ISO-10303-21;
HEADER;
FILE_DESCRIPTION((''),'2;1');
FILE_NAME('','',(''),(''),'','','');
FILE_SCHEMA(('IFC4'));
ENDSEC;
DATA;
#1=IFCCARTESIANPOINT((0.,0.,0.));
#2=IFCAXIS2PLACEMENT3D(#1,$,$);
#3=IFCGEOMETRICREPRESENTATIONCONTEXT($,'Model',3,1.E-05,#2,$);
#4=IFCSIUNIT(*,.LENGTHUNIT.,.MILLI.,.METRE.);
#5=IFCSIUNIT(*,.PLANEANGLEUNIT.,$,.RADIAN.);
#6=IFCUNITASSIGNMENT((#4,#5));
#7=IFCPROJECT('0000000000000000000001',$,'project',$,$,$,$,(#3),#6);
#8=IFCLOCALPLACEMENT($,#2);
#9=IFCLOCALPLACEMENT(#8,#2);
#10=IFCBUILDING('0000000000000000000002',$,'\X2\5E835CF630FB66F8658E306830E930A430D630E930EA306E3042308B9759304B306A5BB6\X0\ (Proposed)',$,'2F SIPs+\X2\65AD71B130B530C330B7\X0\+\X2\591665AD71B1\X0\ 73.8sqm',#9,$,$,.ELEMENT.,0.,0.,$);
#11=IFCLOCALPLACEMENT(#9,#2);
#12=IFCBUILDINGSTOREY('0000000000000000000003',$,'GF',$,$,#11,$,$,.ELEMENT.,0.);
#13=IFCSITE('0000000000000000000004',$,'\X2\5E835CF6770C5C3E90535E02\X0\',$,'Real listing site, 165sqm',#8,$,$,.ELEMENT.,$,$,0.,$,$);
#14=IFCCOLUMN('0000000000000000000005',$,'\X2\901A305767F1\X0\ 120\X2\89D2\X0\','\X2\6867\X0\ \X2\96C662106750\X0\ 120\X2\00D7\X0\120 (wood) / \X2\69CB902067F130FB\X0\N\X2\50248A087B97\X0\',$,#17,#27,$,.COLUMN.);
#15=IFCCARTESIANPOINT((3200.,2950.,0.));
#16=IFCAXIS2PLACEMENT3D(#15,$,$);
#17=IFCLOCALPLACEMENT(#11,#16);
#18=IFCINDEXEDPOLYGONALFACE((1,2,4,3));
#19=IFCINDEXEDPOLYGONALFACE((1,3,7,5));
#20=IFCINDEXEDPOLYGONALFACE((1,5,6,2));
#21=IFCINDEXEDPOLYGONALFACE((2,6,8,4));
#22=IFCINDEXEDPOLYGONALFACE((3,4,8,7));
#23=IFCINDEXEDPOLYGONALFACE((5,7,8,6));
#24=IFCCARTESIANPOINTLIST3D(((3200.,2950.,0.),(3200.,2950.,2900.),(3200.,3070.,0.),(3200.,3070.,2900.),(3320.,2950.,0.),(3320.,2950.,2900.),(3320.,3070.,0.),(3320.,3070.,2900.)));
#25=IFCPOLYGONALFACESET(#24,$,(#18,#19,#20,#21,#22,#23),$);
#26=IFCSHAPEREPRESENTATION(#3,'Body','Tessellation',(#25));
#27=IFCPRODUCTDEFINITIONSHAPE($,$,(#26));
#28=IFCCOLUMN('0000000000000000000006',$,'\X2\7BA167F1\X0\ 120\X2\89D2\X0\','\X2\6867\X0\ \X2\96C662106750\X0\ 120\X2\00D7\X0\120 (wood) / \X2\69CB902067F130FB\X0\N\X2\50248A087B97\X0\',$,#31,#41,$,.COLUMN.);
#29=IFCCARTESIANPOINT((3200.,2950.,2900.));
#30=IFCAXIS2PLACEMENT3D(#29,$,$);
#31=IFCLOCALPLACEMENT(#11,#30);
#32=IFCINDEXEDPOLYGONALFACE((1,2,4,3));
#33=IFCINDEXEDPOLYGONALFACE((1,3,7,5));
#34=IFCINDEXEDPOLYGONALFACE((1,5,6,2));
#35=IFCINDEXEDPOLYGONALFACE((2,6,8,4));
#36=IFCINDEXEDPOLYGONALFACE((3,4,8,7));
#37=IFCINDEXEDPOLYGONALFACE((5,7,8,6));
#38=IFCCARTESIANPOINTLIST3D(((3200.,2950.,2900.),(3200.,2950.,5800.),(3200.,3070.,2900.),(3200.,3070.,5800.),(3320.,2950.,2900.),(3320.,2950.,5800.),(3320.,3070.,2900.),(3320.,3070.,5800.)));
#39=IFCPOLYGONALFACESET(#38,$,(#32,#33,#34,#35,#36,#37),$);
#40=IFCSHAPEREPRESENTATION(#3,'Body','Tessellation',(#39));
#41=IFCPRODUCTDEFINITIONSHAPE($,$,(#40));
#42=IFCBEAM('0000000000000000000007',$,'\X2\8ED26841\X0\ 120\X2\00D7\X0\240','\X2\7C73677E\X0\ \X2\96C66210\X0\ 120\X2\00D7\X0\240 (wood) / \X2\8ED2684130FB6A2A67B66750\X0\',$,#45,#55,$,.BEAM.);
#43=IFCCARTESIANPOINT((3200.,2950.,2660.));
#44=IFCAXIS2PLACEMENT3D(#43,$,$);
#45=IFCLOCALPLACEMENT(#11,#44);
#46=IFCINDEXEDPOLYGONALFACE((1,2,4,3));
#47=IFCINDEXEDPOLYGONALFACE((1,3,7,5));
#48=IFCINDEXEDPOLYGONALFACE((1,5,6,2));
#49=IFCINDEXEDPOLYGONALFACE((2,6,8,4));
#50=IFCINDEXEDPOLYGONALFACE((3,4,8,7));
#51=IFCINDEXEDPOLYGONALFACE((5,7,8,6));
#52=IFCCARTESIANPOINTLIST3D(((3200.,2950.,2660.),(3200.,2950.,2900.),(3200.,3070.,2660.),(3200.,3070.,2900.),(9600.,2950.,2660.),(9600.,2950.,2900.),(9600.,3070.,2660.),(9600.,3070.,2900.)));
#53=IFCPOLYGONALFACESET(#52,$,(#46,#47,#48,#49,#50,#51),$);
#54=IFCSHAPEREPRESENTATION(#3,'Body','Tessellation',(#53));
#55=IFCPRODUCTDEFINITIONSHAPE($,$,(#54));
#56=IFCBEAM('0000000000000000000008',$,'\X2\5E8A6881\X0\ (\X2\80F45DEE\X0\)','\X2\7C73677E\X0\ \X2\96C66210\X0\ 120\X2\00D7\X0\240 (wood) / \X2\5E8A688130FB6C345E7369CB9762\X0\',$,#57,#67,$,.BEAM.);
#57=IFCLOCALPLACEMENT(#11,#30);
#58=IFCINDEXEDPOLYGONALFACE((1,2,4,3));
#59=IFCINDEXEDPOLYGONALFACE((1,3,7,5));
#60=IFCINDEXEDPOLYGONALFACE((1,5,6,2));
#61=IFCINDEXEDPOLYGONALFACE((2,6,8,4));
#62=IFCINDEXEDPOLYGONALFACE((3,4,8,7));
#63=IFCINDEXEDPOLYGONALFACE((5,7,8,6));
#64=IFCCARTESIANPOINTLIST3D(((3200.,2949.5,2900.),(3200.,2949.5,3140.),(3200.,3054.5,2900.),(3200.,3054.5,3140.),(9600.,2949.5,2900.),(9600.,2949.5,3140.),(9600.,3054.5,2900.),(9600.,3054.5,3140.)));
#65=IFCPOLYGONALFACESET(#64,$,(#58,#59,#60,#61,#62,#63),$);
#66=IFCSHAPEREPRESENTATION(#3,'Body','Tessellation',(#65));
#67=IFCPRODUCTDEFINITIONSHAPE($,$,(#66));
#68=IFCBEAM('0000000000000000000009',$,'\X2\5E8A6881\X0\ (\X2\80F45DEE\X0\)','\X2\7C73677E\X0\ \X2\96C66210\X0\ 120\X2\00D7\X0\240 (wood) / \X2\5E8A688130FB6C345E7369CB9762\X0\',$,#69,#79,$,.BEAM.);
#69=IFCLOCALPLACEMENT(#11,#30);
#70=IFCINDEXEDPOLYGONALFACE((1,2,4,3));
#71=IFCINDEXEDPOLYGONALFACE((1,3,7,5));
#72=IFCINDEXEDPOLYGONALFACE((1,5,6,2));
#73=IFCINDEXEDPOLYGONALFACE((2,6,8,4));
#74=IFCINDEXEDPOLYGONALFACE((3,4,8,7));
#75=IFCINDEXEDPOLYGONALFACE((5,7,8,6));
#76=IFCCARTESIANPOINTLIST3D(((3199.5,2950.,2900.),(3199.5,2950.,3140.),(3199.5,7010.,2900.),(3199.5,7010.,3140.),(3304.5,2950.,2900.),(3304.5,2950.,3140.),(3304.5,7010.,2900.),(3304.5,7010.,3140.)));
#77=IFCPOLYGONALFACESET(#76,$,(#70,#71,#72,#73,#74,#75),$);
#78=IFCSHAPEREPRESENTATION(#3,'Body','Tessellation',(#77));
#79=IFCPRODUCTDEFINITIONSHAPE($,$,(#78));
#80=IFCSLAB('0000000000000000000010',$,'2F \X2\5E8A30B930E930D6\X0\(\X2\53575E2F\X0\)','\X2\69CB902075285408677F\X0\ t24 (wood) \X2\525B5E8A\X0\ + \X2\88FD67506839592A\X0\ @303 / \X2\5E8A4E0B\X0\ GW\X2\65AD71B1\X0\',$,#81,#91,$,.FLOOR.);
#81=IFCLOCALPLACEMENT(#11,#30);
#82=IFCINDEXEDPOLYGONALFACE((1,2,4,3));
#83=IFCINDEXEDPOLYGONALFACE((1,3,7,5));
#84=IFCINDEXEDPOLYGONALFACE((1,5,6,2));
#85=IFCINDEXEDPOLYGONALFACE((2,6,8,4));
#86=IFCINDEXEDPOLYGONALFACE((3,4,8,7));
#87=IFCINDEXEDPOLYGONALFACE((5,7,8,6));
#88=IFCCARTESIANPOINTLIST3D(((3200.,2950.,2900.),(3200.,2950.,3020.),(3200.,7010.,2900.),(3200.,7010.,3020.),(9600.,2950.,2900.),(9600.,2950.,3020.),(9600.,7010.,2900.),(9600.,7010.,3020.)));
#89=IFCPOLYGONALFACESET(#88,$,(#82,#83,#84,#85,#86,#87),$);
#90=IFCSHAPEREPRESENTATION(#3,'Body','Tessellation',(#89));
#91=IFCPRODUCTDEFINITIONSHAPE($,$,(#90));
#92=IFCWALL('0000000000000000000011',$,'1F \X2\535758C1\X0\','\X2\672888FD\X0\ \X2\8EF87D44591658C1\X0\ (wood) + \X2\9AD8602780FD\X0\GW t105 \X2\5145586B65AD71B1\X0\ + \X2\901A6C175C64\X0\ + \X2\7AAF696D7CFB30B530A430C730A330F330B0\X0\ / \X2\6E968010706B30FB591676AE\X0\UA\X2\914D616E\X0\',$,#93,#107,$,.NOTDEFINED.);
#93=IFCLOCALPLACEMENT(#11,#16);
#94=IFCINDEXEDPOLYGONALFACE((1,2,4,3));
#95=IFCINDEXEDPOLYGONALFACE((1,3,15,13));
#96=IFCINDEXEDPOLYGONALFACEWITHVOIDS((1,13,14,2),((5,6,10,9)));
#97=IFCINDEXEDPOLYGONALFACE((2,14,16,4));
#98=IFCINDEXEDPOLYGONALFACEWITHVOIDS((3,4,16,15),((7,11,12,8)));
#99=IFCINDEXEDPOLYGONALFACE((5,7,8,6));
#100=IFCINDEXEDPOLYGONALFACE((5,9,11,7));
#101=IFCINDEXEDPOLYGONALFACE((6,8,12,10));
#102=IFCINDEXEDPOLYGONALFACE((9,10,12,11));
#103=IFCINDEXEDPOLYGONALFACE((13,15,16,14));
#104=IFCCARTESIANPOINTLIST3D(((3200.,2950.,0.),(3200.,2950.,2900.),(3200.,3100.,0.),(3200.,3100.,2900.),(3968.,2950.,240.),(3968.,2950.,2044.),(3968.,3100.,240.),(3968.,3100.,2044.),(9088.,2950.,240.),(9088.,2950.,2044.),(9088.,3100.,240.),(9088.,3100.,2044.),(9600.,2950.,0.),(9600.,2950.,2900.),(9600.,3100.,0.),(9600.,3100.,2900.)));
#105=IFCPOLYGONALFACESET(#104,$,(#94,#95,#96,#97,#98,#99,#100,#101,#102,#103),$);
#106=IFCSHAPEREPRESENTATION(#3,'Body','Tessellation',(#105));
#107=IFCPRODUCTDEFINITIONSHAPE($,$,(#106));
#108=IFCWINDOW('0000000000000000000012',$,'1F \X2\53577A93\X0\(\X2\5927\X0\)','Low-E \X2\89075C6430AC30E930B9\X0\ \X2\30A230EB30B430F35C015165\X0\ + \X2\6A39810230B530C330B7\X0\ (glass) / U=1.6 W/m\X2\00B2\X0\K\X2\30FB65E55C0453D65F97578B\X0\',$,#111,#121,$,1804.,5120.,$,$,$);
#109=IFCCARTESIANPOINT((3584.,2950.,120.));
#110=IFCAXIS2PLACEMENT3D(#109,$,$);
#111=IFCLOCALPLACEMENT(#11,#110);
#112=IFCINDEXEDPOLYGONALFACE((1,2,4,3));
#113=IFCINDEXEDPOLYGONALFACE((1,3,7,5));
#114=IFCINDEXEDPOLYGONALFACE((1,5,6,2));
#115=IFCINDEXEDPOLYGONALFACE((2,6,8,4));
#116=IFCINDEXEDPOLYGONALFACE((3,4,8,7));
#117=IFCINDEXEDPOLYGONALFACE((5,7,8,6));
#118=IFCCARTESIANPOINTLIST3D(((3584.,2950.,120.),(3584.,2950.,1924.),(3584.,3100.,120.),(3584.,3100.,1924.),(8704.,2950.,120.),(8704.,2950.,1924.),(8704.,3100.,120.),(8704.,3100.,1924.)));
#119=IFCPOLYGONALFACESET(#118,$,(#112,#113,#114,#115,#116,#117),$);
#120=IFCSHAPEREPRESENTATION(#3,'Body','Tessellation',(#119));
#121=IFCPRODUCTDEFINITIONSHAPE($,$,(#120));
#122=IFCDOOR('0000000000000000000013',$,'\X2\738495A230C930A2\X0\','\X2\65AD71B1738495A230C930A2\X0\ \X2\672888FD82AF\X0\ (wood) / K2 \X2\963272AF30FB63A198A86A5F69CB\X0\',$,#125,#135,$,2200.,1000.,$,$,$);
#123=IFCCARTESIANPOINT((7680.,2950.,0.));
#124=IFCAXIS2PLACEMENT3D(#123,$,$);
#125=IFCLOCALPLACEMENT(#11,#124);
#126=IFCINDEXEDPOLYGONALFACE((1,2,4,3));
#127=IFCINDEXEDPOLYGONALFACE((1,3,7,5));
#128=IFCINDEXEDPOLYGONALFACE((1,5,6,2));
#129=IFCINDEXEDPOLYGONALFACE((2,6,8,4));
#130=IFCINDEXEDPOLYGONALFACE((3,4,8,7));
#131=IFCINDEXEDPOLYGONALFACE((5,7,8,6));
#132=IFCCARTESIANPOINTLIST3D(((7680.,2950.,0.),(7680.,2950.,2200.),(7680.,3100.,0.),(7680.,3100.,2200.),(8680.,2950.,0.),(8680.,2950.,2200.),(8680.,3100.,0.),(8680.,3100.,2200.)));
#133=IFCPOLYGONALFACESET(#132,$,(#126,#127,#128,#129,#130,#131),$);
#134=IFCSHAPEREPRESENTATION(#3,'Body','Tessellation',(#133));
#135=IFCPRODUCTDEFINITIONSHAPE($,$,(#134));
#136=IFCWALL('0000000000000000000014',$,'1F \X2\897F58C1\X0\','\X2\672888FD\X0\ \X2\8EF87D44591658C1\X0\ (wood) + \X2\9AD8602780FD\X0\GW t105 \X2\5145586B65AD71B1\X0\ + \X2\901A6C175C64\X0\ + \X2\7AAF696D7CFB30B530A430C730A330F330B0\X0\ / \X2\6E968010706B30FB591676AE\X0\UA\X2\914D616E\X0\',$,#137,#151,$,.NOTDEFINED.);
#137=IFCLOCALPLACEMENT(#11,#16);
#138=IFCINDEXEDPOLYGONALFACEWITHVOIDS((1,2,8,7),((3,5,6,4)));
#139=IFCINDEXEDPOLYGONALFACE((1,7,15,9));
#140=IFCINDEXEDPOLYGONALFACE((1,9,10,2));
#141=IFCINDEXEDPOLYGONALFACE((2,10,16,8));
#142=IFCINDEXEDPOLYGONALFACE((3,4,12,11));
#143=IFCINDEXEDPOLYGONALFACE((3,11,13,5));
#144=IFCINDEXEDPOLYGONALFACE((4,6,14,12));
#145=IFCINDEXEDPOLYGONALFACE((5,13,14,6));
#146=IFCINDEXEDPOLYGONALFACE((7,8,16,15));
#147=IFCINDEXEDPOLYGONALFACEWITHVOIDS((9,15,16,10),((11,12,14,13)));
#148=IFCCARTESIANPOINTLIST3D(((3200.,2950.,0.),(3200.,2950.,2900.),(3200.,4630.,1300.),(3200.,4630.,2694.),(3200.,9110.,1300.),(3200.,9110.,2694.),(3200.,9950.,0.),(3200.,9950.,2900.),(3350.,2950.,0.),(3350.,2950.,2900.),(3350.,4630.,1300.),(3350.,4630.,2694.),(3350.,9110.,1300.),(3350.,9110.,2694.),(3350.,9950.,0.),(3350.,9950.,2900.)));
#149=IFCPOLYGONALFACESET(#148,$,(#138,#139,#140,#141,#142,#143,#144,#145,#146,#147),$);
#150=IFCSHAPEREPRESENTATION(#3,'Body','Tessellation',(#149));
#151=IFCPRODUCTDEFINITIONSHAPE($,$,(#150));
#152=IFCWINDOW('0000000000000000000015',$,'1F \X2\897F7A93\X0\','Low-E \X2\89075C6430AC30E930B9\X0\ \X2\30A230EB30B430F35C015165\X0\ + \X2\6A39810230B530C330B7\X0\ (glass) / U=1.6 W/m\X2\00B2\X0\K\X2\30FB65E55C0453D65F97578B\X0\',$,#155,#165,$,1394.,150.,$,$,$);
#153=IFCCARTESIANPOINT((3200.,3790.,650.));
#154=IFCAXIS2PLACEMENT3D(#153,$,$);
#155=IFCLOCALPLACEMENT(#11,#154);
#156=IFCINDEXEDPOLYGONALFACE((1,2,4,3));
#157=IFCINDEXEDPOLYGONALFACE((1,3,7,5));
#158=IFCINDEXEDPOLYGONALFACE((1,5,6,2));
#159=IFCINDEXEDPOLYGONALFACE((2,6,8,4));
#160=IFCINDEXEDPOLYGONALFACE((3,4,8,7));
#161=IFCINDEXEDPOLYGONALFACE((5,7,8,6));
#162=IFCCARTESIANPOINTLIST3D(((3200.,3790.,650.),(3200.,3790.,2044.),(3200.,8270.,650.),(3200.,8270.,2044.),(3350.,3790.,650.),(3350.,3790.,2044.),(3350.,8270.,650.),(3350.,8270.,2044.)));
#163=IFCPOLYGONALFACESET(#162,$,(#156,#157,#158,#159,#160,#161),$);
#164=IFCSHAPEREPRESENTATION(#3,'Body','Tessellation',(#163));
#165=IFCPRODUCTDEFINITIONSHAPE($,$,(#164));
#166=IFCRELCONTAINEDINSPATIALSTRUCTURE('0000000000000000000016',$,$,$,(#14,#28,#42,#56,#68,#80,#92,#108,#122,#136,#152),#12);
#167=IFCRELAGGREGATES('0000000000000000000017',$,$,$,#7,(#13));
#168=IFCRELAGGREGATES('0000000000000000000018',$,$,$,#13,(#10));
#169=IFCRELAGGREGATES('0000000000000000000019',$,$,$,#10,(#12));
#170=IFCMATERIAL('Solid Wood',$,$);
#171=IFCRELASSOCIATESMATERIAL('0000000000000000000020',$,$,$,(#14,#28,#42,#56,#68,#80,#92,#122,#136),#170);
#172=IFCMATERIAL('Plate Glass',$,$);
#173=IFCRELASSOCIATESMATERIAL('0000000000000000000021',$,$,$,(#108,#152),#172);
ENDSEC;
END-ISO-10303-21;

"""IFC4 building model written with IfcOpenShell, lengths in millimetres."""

from ifc_helpers import new_model, si_unit, frame, frame_2d, origin, place, context, project, spatial, rectangle, extrude, material, element, fill, save


model = new_model("IFC4")

# Units and contexts
model_context = context("Model", 3, precision=1e-05, world=origin())
ifc_project = project(units=[si_unit("LENGTHUNIT", "METRE", prefix="MILLI"), si_unit("PLANEANGLEUNIT", "RADIAN")], contexts=[model_context])

# Site, building, storey
site_placement = place(None, origin())
site = spatial("IfcSite", under=ifc_project, at=site_placement, Name="広島県尾道市", ObjectType="Real listing site, 165sqm", CompositionType="ELEMENT", RefElevation=0.0)
building_placement = place(site_placement, origin())
building = spatial("IfcBuilding", under=site, at=building_placement, Name="広島・書斎とライブラリのある静かな家 (Proposed)", ObjectType="2F SIPs+断熱サッシ+外断熱 73.8sqm", CompositionType="ELEMENT", ElevationOfRefHeight=0.0, ElevationOfTerrain=0.0)
storey_placement = place(building_placement, origin())
storey = spatial("IfcBuildingStorey", under=building, at=storey_placement, Name="GF", CompositionType="ELEMENT", Elevation=0.0)

# Columns
ifc_material_1 = material(Name="Solid Wood")
column_1_placement = place(storey_placement, frame((3200.0, 2950.0, 0.0)))
element("IfcColumn", 1, at=column_1_placement, inside=storey, material=ifc_material_1, Name="通し柱 120角", Description="桧 集成材 120×120 (wood) / 構造柱・N値計算", PredefinedType="COLUMN", context=model_context, shape_type="SweptSolid", body=[
    extrude(rectangle(XDim=120.0, YDim=120.0, at=frame_2d((60.0, 60.0))), frame((3200.0, 2950.0, 0.0)), (0.0, 0.0, 1.0), 2900.0),
])
column_2_placement = place(storey_placement, frame((3200.0, 2950.0, 2900.0)))
element("IfcColumn", 2, at=column_2_placement, inside=storey, material=ifc_material_1, Name="管柱 120角", Description="桧 集成材 120×120 (wood) / 構造柱・N値計算", PredefinedType="COLUMN", context=model_context, shape_type="SweptSolid", body=[
    extrude(rectangle(XDim=120.0, YDim=120.0, at=frame_2d((60.0, 60.0))), frame((3200.0, 2950.0, 2900.0)), (0.0, 0.0, 1.0), 2900.0),
])

# Beams
beam_1_placement = place(storey_placement, frame((3200.0, 2950.0, 2660.0)))
element("IfcBeam", 3, at=beam_1_placement, inside=storey, material=ifc_material_1, Name="軒桁 120×240", Description="米松 集成 120×240 (wood) / 軒桁・横架材", PredefinedType="BEAM", context=model_context, shape_type="SweptSolid", body=[
    extrude(rectangle(XDim=6400.0, YDim=120.0, at=frame_2d((3200.0, 60.0))), frame((3200.0, 2950.0, 2660.0)), (0.0, 0.0, 1.0), 240.0),
])
beam_2_placement = place(storey_placement, frame((3200.0, 2950.0, 2900.0)))
element("IfcBeam", 4, at=beam_2_placement, inside=storey, material=ifc_material_1, Name="床梁 (胴差)", Description="米松 集成 120×240 (wood) / 床梁・水平構面", PredefinedType="BEAM", context=model_context, shape_type="SweptSolid", body=[
    extrude(rectangle(XDim=6400.0, YDim=105.0, at=frame_2d((3200.0, 52.0))), frame((3200.0, 2950.0, 2900.0)), (0.0, 0.0, 1.0), 240.0),
])
beam_3_placement = place(storey_placement, frame((3200.0, 2950.0, 2900.0)))
element("IfcBeam", 5, at=beam_3_placement, inside=storey, material=ifc_material_1, Name="床梁 (胴差)", Description="米松 集成 120×240 (wood) / 床梁・水平構面", PredefinedType="BEAM", context=model_context, shape_type="SweptSolid", body=[
    extrude(rectangle(XDim=105.0, YDim=4060.0, at=frame_2d((52.0, 2030.0))), frame((3200.0, 2950.0, 2900.0)), (0.0, 0.0, 1.0), 240.0),
])

# Slab
slab_1_placement = place(storey_placement, frame((3200.0, 2950.0, 2900.0)))
element("IfcSlab", 6, at=slab_1_placement, inside=storey, material=ifc_material_1, Name="2F 床スラブ(南帯)", Description="構造用合板 t24 (wood) 剛床 + 製材根太 @303 / 床下 GW断熱", PredefinedType="FLOOR", context=model_context, shape_type="SweptSolid", body=[
    extrude(rectangle(XDim=6400.0, YDim=4060.0, at=frame_2d((3200.0, 2030.0))), frame((3200.0, 2950.0, 2900.0)), (0.0, 0.0, 1.0), 120.0),
])

# Wall, openings, window, door
wall_1_placement = place(storey_placement, frame((3200.0, 2950.0, 0.0)))
wall_1 = element("IfcWall", 7, at=wall_1_placement, inside=storey, material=ifc_material_1, Name="1F 南壁", Description="木製 軸組外壁 (wood) + 高性能GW t105 充填断熱 + 通気層 + 窯業系サイディング / 準耐火・外皮UA配慮", PredefinedType="NOTDEFINED", context=model_context, shape_type="SweptSolid", body=[
    extrude(rectangle(XDim=6400.0, YDim=150.0, at=frame_2d((3200.0, 75.0))), frame((3200.0, 2950.0, 0.0)), (0.0, 0.0, 1.0), 2900.0),
])
opening_1_placement = place(storey_placement, frame((3584.0, 2950.0, 120.0)))
opening_1 = element("IfcOpeningElement", 8, at=opening_1_placement, cuts=wall_1, PredefinedType="NOTDEFINED", context=model_context, shape_type="SweptSolid", body=[
    extrude(rectangle(XDim=5120.0, YDim=150.0, at=frame_2d((2560.0, 75.0))), frame((3584.0, 2950.0, 120.0)), (0.0, 0.0, 1.0), 1804.0),
])
opening_2_placement = place(storey_placement, frame((7680.0, 2950.0, 0.0)))
opening_2 = element("IfcOpeningElement", 9, at=opening_2_placement, cuts=wall_1, PredefinedType="NOTDEFINED", context=model_context, shape_type="SweptSolid", body=[
    extrude(rectangle(XDim=1000.0, YDim=150.0, at=frame_2d((500.0, 75.0))), frame((7680.0, 2950.0, 0.0)), (0.0, 0.0, 1.0), 2200.0),
])
ifc_material_2 = material(Name="Plate Glass")
window_1_placement = place(storey_placement, frame((3584.0, 2950.0, 120.0)))
window_1 = element("IfcWindow", 10, at=window_1_placement, inside=storey, material=ifc_material_2, Name="1F 南窓(大)", Description="Low-E 複層ガラス アルゴン封入 + 樹脂サッシ (glass) / U=1.6 W/m²K・日射取得型", OverallHeight=1804.0, OverallWidth=5120.0, context=model_context, shape_type="SweptSolid", body=[
    extrude(rectangle(XDim=5120.0, YDim=150.0, at=frame_2d((2560.0, 75.0))), frame((3584.0, 2950.0, 120.0)), (0.0, 0.0, 1.0), 1804.0),
])
fill(opening_1, window_1)
door_placement = place(storey_placement, frame((7680.0, 2950.0, 0.0)))
door = element("IfcDoor", 11, at=door_placement, inside=storey, material=ifc_material_1, Name="玄関ドア", Description="断熱玄関ドア 木製芯 (wood) / K2 防犯・採風機構", OverallHeight=2200.0, OverallWidth=1000.0, context=model_context, shape_type="SweptSolid", body=[
    extrude(rectangle(XDim=1000.0, YDim=150.0, at=frame_2d((500.0, 75.0))), frame((7680.0, 2950.0, 0.0)), (0.0, 0.0, 1.0), 2200.0),
])
fill(opening_2, door)

# Wall, opening, window
wall_2_placement = place(storey_placement, frame((3200.0, 2950.0, 0.0)))
wall_2 = element("IfcWall", 12, at=wall_2_placement, inside=storey, material=ifc_material_1, Name="1F 西壁", Description="木製 軸組外壁 (wood) + 高性能GW t105 充填断熱 + 通気層 + 窯業系サイディング / 準耐火・外皮UA配慮", PredefinedType="NOTDEFINED", context=model_context, shape_type="SweptSolid", body=[
    extrude(rectangle(XDim=150.0, YDim=7000.0, at=frame_2d((75.0, 3500.0))), frame((3200.0, 2950.0, 0.0)), (0.0, 0.0, 1.0), 2900.0),
])
opening_3_placement = place(storey_placement, frame((3200.0, 3790.0, 650.0)))
opening_3 = element("IfcOpeningElement", 13, at=opening_3_placement, cuts=wall_2, PredefinedType="NOTDEFINED", context=model_context, shape_type="SweptSolid", body=[
    extrude(rectangle(XDim=150.0, YDim=4480.0, at=frame_2d((75.0, 2240.0))), frame((3200.0, 3790.0, 650.0)), (0.0, 0.0, 1.0), 1394.0),
])
window_2_placement = place(storey_placement, frame((3200.0, 3790.0, 650.0)))
window_2 = element("IfcWindow", 14, at=window_2_placement, inside=storey, material=ifc_material_2, Name="1F 西窓", Description="Low-E 複層ガラス アルゴン封入 + 樹脂サッシ (glass) / U=1.6 W/m²K・日射取得型", OverallHeight=1394.0, OverallWidth=150.0, context=model_context, shape_type="SweptSolid", body=[
    extrude(rectangle(XDim=150.0, YDim=4480.0, at=frame_2d((75.0, 2240.0))), frame((3200.0, 3790.0, 650.0)), (0.0, 0.0, 1.0), 1394.0),
])
fill(opening_3, window_2)

save(model, "model.ifc")
